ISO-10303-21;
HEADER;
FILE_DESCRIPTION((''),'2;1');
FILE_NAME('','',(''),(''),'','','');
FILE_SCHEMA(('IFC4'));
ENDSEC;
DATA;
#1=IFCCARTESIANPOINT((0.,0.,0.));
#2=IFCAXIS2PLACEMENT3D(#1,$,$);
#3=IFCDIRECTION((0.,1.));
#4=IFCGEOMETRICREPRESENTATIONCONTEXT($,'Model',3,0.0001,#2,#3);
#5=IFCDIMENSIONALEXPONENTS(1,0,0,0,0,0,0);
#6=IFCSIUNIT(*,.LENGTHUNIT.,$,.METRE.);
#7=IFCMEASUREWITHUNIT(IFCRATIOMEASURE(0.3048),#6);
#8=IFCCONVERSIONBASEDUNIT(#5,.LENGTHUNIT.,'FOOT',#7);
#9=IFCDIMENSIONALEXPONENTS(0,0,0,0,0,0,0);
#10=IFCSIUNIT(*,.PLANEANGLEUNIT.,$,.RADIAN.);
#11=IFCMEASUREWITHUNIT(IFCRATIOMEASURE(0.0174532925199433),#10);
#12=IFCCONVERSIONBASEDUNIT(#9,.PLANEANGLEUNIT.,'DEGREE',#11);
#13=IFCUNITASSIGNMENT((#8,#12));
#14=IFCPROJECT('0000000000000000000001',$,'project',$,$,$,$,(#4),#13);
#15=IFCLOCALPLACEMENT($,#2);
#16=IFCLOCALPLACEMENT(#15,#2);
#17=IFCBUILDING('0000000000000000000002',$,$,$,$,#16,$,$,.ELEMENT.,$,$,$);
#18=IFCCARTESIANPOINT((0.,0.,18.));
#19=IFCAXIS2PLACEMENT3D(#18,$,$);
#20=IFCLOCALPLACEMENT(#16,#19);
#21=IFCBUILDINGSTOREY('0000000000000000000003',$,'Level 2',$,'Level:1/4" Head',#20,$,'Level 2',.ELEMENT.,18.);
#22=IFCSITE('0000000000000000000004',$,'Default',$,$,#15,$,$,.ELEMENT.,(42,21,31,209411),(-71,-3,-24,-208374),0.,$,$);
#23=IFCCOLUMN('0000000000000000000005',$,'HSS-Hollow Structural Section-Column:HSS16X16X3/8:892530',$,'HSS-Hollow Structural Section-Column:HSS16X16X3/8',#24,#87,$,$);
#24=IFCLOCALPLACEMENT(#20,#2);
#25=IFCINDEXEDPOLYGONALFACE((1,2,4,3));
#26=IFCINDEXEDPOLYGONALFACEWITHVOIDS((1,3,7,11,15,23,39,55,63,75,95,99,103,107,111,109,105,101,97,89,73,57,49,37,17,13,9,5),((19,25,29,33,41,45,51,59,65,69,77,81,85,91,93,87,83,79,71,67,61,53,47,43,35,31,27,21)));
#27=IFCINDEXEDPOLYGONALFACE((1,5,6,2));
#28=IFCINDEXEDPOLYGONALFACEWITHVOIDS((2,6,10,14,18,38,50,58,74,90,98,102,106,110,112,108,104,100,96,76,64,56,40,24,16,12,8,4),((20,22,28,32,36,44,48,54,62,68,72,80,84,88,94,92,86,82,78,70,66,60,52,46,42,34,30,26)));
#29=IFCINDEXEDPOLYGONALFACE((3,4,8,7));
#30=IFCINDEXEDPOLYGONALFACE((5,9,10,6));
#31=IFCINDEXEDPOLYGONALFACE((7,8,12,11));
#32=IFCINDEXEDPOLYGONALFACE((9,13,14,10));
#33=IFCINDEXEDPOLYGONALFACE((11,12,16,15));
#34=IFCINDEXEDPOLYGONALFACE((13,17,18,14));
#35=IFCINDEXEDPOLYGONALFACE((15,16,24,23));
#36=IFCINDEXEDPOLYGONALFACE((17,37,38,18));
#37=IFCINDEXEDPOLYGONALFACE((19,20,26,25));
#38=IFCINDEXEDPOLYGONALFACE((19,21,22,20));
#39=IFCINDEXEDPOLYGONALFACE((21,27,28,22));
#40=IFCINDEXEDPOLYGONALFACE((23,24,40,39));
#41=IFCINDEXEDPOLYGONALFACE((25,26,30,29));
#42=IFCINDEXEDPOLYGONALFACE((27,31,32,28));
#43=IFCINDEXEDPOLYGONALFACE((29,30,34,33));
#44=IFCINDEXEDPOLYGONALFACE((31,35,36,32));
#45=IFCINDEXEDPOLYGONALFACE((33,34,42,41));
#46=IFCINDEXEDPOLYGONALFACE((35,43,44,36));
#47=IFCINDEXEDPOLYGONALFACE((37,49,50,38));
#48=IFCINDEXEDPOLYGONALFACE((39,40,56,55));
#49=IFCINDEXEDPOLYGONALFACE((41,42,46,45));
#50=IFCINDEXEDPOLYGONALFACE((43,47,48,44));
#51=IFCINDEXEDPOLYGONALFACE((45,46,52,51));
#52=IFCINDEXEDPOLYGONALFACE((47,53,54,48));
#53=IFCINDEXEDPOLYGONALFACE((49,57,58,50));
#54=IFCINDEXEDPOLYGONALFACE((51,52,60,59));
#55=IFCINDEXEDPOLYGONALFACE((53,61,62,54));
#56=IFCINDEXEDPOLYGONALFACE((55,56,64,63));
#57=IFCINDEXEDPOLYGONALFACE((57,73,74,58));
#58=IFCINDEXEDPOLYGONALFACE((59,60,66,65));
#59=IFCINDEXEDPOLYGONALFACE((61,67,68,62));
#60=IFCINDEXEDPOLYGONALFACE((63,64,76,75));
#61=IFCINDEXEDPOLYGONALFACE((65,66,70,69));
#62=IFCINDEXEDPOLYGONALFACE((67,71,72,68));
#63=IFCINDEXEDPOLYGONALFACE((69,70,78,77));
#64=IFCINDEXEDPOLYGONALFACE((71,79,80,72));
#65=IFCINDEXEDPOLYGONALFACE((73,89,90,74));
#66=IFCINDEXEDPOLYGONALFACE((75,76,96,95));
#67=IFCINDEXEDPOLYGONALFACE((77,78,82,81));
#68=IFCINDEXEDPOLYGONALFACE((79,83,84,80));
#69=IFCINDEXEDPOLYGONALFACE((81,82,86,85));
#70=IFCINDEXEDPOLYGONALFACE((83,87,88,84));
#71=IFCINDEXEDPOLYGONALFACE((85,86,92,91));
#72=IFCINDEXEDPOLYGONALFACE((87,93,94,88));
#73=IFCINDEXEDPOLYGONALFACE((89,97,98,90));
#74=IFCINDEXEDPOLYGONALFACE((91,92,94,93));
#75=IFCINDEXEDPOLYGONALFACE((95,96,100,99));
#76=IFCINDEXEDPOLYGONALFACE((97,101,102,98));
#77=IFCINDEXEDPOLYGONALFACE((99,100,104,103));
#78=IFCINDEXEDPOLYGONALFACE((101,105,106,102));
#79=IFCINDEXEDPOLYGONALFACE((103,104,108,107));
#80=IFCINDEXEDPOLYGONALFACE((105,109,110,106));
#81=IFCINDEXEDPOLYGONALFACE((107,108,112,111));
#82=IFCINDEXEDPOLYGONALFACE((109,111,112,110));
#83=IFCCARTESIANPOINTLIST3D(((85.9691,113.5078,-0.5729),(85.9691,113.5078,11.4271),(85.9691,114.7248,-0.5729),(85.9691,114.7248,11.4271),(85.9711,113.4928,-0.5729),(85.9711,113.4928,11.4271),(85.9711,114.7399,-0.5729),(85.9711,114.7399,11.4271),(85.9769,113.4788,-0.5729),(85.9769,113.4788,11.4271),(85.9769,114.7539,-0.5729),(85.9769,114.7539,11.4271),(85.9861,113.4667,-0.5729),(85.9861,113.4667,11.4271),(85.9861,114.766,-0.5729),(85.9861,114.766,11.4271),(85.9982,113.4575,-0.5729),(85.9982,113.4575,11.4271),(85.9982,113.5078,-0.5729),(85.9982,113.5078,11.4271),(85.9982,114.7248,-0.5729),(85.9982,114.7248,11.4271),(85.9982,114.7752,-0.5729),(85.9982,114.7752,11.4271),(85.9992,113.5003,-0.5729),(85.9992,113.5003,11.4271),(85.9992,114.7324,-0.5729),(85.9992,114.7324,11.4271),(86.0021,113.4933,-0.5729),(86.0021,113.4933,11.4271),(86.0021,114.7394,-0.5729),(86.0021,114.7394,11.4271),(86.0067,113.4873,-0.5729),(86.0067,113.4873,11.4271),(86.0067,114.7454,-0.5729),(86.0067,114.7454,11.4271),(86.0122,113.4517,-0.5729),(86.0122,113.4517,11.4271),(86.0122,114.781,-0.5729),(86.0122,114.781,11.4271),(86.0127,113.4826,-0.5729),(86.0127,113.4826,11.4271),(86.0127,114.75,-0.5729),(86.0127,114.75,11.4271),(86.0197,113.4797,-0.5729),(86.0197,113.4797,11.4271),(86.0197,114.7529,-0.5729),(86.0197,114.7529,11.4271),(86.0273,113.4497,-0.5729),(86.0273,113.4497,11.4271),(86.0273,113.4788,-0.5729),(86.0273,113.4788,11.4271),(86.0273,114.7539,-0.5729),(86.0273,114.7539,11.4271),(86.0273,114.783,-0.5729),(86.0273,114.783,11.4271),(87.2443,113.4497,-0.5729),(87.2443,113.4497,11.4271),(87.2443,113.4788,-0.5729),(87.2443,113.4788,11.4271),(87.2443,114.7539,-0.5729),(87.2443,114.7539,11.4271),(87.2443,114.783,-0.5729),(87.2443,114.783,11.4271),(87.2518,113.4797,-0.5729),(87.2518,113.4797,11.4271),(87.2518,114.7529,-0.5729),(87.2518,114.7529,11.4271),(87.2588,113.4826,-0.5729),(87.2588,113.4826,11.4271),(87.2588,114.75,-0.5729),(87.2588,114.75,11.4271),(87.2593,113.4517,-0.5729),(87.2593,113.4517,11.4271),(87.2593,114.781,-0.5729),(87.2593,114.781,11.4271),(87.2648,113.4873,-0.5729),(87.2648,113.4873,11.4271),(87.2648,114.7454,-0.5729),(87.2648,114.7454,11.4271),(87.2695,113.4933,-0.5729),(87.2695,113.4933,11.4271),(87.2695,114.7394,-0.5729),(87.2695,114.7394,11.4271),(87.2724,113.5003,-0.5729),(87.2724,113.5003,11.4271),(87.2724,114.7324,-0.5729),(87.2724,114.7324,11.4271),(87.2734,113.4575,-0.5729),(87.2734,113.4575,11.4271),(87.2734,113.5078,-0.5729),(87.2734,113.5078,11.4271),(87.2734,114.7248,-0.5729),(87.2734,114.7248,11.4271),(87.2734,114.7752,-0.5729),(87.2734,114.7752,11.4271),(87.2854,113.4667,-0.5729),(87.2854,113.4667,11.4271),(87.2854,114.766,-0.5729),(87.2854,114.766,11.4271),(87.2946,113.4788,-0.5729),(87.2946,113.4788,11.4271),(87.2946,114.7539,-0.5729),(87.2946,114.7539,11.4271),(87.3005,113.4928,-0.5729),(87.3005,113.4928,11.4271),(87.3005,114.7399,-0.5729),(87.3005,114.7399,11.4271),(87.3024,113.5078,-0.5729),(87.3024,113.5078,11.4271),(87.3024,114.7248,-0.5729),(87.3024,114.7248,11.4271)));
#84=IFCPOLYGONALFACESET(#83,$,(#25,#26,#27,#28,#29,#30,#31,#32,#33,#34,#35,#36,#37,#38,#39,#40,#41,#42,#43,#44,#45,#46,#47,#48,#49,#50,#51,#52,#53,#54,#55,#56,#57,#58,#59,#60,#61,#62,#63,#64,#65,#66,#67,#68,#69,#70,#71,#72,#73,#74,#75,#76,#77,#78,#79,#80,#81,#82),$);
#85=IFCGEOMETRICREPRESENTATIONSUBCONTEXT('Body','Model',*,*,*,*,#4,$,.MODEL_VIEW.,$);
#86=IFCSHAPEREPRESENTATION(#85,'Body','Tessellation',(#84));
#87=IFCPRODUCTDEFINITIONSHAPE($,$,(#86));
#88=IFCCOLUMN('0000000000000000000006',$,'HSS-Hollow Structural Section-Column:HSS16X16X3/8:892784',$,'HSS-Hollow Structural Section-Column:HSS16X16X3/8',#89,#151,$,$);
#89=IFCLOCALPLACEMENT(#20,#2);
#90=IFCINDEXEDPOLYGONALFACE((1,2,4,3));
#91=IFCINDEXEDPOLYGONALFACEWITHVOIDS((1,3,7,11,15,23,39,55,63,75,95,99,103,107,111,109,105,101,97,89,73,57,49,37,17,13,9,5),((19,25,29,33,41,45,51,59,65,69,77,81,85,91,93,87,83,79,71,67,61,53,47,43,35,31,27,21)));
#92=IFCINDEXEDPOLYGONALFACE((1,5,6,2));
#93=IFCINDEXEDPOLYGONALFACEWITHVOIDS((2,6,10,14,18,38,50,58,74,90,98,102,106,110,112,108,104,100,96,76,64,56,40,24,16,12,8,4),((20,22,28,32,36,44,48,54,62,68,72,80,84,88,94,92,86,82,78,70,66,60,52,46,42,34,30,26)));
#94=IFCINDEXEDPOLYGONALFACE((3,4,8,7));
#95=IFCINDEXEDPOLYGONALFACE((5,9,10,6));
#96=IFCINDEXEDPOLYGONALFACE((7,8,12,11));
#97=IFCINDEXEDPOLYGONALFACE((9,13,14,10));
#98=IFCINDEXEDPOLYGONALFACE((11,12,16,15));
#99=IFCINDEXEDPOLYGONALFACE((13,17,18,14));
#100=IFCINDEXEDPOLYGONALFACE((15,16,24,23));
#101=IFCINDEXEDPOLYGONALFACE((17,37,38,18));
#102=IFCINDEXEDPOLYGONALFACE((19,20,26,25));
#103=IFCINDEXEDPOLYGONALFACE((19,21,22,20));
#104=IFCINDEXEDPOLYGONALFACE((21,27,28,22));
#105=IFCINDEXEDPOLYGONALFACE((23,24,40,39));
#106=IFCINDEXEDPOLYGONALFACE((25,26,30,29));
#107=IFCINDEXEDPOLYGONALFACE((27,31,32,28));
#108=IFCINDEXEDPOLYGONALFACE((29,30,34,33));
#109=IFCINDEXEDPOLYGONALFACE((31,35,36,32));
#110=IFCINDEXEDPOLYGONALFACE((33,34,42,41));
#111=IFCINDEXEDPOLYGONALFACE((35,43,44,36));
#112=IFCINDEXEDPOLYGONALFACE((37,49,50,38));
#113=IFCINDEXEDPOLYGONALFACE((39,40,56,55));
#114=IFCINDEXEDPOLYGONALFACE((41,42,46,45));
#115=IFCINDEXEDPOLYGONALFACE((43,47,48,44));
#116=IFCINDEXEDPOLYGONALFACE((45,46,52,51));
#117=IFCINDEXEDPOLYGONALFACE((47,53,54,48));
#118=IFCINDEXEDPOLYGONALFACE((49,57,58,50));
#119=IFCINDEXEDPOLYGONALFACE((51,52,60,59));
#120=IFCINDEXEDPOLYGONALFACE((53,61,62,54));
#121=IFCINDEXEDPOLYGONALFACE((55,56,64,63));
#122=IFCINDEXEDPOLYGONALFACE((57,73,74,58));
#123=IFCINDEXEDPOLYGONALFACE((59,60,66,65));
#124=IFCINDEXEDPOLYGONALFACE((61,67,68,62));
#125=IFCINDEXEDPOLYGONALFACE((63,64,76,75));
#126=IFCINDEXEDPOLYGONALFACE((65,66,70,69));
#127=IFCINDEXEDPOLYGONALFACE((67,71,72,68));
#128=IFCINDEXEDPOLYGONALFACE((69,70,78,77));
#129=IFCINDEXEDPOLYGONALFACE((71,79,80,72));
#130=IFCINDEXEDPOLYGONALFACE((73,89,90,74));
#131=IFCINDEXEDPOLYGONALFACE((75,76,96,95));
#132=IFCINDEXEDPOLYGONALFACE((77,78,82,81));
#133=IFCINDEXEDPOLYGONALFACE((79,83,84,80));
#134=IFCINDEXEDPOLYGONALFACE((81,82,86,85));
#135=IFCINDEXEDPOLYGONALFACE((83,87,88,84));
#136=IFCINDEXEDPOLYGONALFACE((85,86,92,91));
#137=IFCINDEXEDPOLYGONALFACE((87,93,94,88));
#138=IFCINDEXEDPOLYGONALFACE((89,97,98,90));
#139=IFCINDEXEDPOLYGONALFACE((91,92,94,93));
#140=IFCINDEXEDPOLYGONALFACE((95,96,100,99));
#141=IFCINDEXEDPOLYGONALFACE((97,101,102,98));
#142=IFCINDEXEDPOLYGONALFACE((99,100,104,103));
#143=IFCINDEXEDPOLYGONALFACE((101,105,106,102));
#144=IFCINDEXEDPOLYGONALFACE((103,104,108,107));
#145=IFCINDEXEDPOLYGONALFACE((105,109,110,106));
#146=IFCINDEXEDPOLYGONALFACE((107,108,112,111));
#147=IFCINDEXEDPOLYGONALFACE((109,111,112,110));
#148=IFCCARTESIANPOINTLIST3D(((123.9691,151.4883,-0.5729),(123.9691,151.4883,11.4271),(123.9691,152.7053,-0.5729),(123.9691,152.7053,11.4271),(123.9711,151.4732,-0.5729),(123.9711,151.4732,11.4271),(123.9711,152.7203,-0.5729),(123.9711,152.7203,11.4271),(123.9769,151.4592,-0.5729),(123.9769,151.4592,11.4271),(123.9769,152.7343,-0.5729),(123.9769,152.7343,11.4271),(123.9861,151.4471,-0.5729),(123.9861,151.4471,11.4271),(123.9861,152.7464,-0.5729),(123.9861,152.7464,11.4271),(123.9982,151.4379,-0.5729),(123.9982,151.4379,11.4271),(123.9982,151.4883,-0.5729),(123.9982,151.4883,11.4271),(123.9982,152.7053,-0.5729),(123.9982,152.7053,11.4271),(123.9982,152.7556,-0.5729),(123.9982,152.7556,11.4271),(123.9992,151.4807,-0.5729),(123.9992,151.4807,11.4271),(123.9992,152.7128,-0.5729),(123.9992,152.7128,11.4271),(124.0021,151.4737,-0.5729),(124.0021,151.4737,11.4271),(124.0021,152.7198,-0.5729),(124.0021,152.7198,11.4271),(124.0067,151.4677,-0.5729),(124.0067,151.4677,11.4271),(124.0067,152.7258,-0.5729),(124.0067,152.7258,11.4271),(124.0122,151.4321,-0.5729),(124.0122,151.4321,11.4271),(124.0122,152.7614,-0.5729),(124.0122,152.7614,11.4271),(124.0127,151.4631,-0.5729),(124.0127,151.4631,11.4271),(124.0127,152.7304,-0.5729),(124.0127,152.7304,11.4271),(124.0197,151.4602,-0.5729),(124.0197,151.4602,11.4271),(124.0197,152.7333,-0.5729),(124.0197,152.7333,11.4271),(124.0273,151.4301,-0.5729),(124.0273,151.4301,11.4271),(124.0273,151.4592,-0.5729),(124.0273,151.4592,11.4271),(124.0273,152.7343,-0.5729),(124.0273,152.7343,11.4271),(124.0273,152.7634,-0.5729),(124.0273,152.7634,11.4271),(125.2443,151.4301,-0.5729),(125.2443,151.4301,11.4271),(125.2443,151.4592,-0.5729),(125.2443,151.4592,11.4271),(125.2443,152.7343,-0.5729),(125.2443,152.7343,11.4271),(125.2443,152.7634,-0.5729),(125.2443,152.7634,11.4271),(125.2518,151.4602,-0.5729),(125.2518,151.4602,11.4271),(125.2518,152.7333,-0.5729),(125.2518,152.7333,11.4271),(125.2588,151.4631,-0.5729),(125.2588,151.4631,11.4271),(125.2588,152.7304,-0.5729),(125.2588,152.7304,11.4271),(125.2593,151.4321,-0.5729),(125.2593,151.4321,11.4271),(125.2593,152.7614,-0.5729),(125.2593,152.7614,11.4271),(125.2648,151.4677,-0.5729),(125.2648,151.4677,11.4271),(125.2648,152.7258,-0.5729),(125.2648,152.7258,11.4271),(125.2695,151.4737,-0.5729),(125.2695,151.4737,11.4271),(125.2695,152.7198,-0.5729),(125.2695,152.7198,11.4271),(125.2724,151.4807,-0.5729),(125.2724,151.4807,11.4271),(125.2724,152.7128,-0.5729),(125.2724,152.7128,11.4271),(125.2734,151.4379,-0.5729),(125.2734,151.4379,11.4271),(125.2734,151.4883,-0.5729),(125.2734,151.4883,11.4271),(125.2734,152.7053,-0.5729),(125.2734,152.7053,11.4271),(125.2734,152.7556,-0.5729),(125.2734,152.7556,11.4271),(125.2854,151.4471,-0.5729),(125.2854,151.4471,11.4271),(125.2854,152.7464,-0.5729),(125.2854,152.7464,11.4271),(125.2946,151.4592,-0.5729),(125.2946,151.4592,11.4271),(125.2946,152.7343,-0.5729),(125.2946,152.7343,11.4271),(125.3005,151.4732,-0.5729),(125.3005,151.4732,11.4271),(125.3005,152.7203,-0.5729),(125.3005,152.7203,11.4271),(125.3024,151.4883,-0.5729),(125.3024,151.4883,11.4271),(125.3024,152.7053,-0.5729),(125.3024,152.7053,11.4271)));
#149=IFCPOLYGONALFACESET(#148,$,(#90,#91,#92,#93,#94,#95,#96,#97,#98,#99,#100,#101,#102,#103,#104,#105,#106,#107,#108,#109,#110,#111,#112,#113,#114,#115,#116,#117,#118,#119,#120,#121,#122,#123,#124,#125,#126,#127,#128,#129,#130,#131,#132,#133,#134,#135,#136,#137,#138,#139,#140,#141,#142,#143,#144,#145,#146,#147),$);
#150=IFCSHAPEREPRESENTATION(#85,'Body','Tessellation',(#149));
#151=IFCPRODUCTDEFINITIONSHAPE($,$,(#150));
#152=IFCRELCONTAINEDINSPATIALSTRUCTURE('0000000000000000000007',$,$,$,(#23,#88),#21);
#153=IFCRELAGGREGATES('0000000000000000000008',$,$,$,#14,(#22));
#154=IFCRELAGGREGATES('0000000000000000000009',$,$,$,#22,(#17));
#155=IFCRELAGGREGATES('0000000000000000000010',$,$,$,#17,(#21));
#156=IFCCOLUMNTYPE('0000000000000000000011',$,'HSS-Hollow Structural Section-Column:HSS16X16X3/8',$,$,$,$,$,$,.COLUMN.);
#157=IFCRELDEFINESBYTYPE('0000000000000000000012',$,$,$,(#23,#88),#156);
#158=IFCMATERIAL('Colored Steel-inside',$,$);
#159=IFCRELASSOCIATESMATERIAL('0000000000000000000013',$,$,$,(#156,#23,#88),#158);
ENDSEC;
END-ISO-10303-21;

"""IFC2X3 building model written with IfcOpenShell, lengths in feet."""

from ifc_helpers import new_model, entity, si_unit, converted_unit, direction, frame, frame_2d, origin, place, context, subcontext, project, spatial, polyline, circle_curve, parameter, trimmed, segment, composite_curve, outline, extrude, source, transform, mapped, material, type_object, type_shapes, element, save


model = new_model("IFC2X3")

# Units and contexts
model_context = context("Model", 3, precision=0.0001, world=origin(), true_north=direction((0.0, 1.0)))
body_context = subcontext(model_context, "Body", "Model", "MODEL_VIEW")
ifc_project = project(units=[converted_unit("LENGTHUNIT", "FOOT", entity("IfcRatioMeasure", 0.3048), si_unit("LENGTHUNIT", "METRE"), dimensions=[1, 0, 0, 0, 0, 0, 0]), converted_unit("PLANEANGLEUNIT", "DEGREE", entity("IfcRatioMeasure", 0.0174532925199433), si_unit("PLANEANGLEUNIT", "RADIAN"), dimensions=[0, 0, 0, 0, 0, 0, 0])], contexts=[model_context])

# Site, building, storey
site_placement = place(None, origin())
site = spatial("IfcSite", under=ifc_project, at=site_placement, Name="Default", CompositionType="ELEMENT", RefLatitude=(42, 21, 31, 209411), RefLongitude=(-71, -3, -24, -208374), RefElevation=0.0)
building_placement = place(site_placement, origin())
building = spatial("IfcBuilding", under=site, at=building_placement, CompositionType="ELEMENT")
storey_placement = place(building_placement, frame((0.0, 0.0, 18.0)))
storey = spatial("IfcBuildingStorey", under=building, at=storey_placement, Name="Level 2", ObjectType="Level:1/4\" Head", LongName="Level 2", CompositionType="ELEMENT", Elevation=18.0)

# Columns
ifc_material_1 = material(Name="Colored Steel-inside")
column_type = type_object("IfcColumnType", Name="HSS-Hollow Structural Section-Column:HSS16X16X3/8", PredefinedType="COLUMN", material=ifc_material_1)
shared_shape = source(origin(), body_context, "Body", "SweptSolid", [
    extrude(outline(composite_curve([segment(polyline([(-0.6085, -0.6667), (0.6085, -0.6667)]), True, "CONTINUOUS"), segment(trimmed(circle_curve(frame_2d((0.6085, -0.6085), x_axis=(-1.0, 0.0)), 0.0582), [parameter(90.0)], [parameter(180.0)], True, "PARAMETER"), True, "CONTINUOUS"), segment(polyline([(0.6667, -0.6085), (0.6667, 0.6085)]), True, "CONTINUOUS"), segment(trimmed(circle_curve(frame_2d((0.6085, 0.6085), x_axis=(-1.0, 0.0)), 0.0582), [parameter(180.0)], [parameter(270.0)], True, "PARAMETER"), True, "CONTINUOUS"), segment(polyline([(0.6085, 0.6667), (-0.6085, 0.6667)]), True, "CONTINUOUS"), segment(trimmed(circle_curve(frame_2d((-0.6085, 0.6085), x_axis=(-1.0, 0.0)), 0.0582), [parameter(270.0)], [parameter(360.0)], True, "PARAMETER"), True, "CONTINUOUS"), segment(polyline([(-0.6667, 0.6085), (-0.6667, -0.6085)]), True, "CONTINUOUS"), segment(trimmed(circle_curve(frame_2d((-0.6085, -0.6085), x_axis=(-1.0, 0.0)), 0.0582), [parameter(360.0)], [parameter(90.0)], True, "PARAMETER"), True, "CONTINUOUS")], self_intersect=False), holes=[composite_curve([segment(trimmed(circle_curve(frame_2d((-0.6085, -0.6085), x_axis=(-1.0, 0.0)), 0.0291), [parameter(0.0)], [parameter(90.0)], True, "PARAMETER"), False, "CONTINUOUS"), segment(polyline([(-0.6376, -0.6085), (-0.6376, 0.6085)]), True, "CONTINUOUS"), segment(trimmed(circle_curve(frame_2d((-0.6085, 0.6085), x_axis=(-1.0, 0.0)), 0.0291), [parameter(270.0)], [parameter(360.0)], True, "PARAMETER"), False, "CONTINUOUS"), segment(polyline([(-0.6085, 0.6376), (0.6085, 0.6376)]), True, "CONTINUOUS"), segment(trimmed(circle_curve(frame_2d((0.6085, 0.6085), x_axis=(-1.0, 0.0)), 0.0291), [parameter(180.0)], [parameter(270.0)], True, "PARAMETER"), False, "CONTINUOUS"), segment(polyline([(0.6376, 0.6085), (0.6376, -0.6085)]), True, "CONTINUOUS"), segment(trimmed(circle_curve(frame_2d((0.6085, -0.6085), x_axis=(-1.0, 0.0)), 0.0291), [parameter(90.0)], [parameter(180.0)], True, "PARAMETER"), False, "CONTINUOUS"), segment(polyline([(0.6085, -0.6376), (-0.6085, -0.6376)]), True, "CONTINUOUS")], self_intersect=False)]), frame((0.0, 0.0, 17.4271), z_axis=(0.0, 0.0, 1.0), x_axis=(-1.0, 0.0, 0.0)), (0.0, 0.0, 1.0), 12.0),
])
type_shapes(column_type, [shared_shape])
for number, where, name in (
    (1, (86.6358, 114.1163, -18.0), "HSS-Hollow Structural Section-Column:HSS16X16X3/8:892530"),
    (2, (124.6358, 152.0968, -18.0), "HSS-Hollow Structural Section-Column:HSS16X16X3/8:892784"),
):
    element("IfcColumn", number, at=place(storey_placement, frame(where)), inside=storey, type_object=column_type, material=ifc_material_1, Name=name, ObjectType="HSS-Hollow Structural Section-Column:HSS16X16X3/8", context=body_context, shape_type="MappedRepresentation", body=[
        mapped(shared_shape, transform((0.0, 0.0, 0.0), scale=1.0)),
    ])

save(model, "model.ifc")
